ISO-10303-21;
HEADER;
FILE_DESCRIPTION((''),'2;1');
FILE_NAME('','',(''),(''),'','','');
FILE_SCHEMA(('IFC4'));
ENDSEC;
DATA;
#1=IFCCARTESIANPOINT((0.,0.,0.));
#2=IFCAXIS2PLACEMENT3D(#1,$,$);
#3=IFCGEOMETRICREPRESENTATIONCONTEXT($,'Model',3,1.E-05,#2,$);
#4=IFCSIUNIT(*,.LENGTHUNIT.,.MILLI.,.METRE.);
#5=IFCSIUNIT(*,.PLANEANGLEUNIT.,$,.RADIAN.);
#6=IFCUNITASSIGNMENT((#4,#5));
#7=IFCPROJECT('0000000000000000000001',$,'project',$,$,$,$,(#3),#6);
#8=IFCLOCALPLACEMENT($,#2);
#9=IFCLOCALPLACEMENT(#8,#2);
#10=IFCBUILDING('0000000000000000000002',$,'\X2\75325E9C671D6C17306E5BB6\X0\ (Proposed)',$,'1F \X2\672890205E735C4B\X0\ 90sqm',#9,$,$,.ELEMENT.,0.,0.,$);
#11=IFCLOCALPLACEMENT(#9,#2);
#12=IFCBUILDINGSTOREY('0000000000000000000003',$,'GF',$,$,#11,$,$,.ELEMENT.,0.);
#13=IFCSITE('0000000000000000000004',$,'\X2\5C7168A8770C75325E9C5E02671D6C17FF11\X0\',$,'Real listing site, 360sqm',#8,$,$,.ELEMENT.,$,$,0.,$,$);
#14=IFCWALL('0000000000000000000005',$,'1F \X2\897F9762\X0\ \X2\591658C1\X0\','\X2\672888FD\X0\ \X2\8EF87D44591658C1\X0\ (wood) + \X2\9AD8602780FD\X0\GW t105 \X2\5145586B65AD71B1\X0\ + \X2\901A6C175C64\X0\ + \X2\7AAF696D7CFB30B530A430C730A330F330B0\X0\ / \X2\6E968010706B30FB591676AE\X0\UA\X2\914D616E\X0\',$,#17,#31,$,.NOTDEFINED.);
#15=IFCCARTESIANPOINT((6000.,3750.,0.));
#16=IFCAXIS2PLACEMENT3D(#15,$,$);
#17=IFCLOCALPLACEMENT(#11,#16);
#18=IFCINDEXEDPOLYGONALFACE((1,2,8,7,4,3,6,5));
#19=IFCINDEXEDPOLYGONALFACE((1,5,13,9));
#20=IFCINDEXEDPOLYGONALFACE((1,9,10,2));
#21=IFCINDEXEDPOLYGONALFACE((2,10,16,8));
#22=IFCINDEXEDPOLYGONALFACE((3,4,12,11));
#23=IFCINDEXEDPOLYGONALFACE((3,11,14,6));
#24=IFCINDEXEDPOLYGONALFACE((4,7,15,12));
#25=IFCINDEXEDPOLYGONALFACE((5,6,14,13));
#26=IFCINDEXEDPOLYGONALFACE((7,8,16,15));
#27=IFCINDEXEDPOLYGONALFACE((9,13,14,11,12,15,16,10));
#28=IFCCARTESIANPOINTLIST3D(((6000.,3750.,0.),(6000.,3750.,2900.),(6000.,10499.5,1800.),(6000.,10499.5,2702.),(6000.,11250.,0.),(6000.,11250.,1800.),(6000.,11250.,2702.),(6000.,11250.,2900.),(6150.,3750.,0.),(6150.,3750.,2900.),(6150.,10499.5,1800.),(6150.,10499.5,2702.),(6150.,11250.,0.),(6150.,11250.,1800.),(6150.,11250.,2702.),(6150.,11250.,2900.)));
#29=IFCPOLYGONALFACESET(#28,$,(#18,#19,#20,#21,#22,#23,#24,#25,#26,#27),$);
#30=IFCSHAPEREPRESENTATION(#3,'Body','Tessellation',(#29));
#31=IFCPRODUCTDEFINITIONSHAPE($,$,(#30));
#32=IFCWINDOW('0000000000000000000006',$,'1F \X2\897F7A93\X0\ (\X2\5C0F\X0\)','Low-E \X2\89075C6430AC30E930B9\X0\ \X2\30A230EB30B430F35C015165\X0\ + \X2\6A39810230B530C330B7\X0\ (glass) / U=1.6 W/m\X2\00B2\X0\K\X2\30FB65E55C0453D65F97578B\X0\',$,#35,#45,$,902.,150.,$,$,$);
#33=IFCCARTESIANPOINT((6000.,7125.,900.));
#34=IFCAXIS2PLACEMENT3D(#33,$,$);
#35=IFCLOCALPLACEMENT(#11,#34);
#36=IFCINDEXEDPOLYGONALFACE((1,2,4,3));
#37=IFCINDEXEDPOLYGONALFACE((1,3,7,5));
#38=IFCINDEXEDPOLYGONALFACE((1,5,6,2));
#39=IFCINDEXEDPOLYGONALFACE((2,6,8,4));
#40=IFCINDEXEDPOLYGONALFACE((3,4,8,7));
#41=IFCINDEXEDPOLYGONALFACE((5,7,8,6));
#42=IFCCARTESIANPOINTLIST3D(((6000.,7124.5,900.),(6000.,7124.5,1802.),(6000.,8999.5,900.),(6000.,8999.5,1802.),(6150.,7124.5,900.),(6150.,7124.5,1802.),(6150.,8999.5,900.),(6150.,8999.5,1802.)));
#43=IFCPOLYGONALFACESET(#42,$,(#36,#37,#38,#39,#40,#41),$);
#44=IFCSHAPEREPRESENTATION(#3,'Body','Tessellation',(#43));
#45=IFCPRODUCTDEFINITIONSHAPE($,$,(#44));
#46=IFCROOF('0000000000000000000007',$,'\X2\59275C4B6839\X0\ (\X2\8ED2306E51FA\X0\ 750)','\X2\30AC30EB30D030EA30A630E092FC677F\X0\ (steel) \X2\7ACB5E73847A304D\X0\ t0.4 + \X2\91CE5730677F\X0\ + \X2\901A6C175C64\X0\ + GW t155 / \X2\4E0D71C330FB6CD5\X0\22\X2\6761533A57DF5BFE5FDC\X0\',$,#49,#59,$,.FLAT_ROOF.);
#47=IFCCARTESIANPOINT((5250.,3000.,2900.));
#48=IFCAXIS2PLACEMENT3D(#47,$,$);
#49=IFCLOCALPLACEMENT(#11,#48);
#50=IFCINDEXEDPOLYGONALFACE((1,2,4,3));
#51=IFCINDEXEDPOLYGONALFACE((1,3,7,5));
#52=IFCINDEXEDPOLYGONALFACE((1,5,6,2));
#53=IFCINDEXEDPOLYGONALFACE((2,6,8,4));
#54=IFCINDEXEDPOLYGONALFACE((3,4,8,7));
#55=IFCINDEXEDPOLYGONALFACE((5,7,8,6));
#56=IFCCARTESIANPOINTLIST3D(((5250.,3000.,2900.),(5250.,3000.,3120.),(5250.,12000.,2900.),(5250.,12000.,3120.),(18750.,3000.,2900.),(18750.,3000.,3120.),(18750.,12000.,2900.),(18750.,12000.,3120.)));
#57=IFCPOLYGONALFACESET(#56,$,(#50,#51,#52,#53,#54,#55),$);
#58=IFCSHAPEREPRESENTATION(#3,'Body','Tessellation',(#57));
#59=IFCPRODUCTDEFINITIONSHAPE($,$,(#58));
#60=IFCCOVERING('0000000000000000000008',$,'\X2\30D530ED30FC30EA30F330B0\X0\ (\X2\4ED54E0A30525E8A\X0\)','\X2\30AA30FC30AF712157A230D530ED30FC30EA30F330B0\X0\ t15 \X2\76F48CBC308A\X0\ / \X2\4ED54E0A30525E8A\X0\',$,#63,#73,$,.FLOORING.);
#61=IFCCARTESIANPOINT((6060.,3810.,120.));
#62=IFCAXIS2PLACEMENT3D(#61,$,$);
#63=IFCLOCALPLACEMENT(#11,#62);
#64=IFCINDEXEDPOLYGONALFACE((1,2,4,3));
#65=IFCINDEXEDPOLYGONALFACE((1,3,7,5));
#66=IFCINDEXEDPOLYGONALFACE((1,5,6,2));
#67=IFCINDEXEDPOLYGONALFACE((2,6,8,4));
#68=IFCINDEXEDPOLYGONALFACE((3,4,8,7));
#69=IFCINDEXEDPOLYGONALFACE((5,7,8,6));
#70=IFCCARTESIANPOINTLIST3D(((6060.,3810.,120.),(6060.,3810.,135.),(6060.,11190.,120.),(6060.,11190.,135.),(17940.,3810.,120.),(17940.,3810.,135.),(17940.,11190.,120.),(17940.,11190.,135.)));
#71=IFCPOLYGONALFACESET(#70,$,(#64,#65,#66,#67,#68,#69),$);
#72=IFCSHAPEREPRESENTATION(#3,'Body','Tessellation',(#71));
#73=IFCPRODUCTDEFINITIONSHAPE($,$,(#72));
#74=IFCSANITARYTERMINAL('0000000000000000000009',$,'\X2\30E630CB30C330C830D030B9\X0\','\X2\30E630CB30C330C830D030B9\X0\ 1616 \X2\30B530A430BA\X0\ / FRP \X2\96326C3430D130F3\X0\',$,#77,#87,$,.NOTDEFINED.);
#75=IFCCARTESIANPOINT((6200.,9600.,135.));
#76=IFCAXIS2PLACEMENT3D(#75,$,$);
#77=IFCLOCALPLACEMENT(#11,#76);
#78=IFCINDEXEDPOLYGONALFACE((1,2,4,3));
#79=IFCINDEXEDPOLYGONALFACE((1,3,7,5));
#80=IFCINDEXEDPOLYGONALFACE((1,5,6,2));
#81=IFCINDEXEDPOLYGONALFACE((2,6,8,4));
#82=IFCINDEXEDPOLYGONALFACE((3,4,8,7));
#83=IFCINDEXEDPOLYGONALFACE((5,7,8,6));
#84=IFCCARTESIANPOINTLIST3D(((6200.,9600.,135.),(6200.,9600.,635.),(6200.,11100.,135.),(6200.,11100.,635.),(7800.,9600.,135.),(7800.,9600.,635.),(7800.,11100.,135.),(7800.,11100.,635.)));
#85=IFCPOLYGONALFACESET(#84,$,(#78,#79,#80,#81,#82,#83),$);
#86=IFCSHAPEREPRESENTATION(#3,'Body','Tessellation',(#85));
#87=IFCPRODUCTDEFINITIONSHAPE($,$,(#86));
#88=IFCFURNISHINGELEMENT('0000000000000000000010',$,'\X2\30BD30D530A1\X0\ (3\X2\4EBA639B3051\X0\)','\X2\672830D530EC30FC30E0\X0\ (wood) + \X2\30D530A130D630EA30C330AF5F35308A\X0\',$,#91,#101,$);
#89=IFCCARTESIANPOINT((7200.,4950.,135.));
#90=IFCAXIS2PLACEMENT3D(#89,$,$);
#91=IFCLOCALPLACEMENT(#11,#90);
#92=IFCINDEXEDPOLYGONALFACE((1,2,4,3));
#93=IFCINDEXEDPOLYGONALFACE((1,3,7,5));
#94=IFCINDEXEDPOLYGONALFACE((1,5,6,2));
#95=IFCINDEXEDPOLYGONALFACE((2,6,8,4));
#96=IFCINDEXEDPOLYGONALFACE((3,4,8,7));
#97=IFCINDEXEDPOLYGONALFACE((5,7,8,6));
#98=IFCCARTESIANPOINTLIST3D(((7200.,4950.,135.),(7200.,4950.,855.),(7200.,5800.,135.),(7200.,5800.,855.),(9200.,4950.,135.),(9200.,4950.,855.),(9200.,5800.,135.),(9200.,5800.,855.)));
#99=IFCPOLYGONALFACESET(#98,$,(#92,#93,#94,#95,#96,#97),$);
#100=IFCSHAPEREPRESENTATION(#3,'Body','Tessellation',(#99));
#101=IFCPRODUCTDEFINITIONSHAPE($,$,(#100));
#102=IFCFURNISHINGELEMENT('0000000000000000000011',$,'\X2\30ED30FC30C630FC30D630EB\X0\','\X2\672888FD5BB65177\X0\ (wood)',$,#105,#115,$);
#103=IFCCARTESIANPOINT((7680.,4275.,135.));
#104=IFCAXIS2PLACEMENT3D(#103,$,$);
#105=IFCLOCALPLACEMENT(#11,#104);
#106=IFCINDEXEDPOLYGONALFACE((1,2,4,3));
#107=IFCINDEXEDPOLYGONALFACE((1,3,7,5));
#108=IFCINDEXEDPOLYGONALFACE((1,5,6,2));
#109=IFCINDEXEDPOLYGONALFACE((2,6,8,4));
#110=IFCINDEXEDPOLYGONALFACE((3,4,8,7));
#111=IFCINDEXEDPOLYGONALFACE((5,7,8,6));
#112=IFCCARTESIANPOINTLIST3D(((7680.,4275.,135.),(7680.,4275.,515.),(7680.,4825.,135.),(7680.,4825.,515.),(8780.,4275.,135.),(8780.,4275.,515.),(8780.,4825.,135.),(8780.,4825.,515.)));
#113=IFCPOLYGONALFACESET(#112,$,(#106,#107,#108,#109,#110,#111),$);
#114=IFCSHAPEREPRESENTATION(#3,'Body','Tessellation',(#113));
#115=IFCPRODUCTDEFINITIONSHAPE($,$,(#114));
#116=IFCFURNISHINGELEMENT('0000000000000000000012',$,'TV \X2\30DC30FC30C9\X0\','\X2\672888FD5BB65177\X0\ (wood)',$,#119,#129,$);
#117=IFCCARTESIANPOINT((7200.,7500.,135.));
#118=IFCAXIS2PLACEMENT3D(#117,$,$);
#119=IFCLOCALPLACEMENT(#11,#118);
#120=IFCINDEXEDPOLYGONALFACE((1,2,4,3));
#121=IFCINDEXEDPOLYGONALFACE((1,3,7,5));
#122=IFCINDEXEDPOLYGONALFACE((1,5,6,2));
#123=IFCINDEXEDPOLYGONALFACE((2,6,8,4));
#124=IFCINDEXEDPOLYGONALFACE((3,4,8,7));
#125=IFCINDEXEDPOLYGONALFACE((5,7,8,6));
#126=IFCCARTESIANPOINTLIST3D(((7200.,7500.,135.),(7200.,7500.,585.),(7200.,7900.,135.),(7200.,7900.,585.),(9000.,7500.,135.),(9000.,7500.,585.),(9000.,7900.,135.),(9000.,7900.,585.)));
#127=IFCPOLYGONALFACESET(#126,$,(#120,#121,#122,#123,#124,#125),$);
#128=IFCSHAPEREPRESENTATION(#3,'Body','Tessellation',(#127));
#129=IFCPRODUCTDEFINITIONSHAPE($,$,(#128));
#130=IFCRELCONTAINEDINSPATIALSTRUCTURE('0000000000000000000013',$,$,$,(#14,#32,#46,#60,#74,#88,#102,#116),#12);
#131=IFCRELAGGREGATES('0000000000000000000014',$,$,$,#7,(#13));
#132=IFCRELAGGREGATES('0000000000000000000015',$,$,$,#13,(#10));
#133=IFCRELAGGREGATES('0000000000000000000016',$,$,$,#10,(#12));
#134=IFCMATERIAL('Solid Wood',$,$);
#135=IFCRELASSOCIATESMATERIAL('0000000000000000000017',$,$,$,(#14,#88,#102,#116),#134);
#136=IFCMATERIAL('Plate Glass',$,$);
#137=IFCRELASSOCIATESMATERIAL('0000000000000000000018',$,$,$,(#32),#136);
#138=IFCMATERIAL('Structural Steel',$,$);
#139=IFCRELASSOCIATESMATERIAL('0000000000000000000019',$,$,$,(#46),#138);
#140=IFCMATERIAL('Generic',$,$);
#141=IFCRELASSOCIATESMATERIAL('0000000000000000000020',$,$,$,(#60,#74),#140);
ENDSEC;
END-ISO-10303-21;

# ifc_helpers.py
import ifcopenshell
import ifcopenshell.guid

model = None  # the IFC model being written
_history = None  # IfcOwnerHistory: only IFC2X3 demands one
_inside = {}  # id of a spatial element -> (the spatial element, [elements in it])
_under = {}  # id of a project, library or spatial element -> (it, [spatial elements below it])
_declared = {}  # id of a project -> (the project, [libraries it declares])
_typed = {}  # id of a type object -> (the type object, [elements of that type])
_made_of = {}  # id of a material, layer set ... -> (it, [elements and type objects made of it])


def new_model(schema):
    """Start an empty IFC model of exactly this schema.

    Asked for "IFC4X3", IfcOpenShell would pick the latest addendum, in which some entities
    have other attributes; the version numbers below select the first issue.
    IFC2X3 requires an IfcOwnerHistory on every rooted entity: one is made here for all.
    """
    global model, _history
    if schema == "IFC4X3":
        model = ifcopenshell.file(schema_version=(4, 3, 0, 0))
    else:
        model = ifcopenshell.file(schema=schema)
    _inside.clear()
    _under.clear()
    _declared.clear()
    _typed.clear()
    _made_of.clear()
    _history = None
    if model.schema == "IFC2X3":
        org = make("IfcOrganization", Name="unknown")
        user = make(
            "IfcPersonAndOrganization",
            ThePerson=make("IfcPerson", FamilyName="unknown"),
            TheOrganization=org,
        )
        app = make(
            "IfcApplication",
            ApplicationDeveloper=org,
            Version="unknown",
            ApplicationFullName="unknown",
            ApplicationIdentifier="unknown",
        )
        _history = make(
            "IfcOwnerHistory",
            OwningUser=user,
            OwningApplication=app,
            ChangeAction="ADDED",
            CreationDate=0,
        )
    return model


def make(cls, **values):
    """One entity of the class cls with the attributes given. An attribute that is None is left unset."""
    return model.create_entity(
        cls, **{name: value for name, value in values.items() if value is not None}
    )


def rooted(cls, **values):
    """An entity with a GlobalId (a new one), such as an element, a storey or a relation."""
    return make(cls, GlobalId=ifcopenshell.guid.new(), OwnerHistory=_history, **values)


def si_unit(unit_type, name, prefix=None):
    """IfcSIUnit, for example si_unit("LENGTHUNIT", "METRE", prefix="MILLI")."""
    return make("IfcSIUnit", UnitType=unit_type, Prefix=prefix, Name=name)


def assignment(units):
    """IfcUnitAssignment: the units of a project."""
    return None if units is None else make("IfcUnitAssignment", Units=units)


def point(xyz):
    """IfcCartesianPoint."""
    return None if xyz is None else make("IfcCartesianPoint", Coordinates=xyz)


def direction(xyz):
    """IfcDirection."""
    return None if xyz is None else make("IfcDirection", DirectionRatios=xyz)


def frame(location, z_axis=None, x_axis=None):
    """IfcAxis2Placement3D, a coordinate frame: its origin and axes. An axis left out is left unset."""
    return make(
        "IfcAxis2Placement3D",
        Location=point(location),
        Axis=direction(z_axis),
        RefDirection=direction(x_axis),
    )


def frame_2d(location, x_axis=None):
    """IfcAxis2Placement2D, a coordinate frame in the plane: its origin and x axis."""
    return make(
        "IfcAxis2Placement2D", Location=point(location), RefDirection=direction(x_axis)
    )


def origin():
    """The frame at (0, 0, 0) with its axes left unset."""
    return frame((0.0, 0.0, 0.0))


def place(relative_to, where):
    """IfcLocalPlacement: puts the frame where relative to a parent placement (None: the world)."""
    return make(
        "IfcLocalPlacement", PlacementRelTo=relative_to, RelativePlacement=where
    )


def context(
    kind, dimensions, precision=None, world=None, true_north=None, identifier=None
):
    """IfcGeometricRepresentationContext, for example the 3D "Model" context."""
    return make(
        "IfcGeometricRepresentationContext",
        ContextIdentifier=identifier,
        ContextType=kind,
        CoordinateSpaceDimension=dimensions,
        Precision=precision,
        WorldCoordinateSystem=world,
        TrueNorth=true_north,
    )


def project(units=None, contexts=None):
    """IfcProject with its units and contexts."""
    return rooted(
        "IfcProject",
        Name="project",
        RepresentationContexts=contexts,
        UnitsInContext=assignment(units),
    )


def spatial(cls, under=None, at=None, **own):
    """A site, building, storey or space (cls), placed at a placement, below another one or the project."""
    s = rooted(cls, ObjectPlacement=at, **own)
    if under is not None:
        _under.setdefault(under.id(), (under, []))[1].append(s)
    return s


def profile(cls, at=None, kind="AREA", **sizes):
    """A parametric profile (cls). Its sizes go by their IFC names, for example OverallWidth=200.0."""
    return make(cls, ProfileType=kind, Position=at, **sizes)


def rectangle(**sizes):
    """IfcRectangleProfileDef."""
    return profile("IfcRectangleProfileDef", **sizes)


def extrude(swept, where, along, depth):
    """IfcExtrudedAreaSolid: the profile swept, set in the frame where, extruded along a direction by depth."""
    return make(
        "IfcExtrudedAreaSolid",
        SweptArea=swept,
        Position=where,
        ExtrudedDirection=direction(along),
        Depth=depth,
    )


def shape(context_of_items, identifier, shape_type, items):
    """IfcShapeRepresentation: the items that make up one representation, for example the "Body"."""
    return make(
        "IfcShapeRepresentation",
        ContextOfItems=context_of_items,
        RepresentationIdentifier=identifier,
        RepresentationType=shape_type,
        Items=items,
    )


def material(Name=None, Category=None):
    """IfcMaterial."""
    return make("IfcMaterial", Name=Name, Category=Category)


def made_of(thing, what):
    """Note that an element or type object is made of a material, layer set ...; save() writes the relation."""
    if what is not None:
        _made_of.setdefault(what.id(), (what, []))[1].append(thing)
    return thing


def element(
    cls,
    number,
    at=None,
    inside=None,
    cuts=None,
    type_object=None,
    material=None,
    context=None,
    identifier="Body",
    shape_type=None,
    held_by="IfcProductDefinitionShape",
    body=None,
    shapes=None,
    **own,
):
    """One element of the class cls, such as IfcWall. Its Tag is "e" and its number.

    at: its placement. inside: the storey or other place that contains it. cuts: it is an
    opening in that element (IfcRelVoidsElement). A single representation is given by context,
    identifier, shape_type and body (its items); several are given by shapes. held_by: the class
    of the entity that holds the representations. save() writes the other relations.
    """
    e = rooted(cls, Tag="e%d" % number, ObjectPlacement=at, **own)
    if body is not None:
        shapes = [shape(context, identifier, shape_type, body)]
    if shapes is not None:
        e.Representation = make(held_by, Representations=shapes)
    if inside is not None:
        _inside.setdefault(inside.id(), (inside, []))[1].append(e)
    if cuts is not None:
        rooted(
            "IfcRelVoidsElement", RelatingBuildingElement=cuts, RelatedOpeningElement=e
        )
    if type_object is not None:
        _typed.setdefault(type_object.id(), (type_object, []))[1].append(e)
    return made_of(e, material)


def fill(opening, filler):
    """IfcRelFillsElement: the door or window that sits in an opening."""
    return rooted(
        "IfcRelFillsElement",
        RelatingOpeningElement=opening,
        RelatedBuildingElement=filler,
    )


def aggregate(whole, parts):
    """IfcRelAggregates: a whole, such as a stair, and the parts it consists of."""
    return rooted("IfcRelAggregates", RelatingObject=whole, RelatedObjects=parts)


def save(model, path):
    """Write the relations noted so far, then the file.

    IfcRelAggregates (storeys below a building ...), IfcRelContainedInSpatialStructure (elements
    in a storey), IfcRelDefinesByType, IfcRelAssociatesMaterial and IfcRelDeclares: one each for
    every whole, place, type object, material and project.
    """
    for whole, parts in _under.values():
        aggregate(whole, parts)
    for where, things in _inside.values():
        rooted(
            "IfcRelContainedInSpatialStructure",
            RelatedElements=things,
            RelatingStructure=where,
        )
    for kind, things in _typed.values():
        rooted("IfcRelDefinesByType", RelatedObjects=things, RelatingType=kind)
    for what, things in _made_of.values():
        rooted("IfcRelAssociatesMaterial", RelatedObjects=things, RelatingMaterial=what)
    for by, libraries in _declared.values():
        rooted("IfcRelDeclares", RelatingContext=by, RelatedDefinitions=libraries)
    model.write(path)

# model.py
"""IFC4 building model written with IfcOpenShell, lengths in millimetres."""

from ifc_helpers import new_model, si_unit, frame, frame_2d, origin, place, context, project, spatial, rectangle, extrude, material, element, fill, save


model = new_model("IFC4")

# Units and contexts
model_context = context("Model", 3, precision=1e-05, world=origin())
ifc_project = project(units=[si_unit("LENGTHUNIT", "METRE", prefix="MILLI"), si_unit("PLANEANGLEUNIT", "RADIAN")], contexts=[model_context])

# Site, building, storey
site_placement = place(None, origin())
site = spatial("IfcSite", under=ifc_project, at=site_placement, Name="山梨県甲府市朝気１", ObjectType="Real listing site, 360sqm", CompositionType="ELEMENT", RefElevation=0.0)
building_placement = place(site_placement, origin())
building = spatial("IfcBuilding", under=site, at=building_placement, Name="甲府朝気の家 (Proposed)", ObjectType="1F 木造平屋 90sqm", CompositionType="ELEMENT", ElevationOfRefHeight=0.0, ElevationOfTerrain=0.0)
storey_placement = place(building_placement, origin())
storey = spatial("IfcBuildingStorey", under=building, at=storey_placement, Name="GF", CompositionType="ELEMENT", Elevation=0.0)

# Shared definitions
ifc_material_1 = material(Name="Solid Wood")

# Shared definitions
ifc_material_2 = material(Name="Plate Glass")

# Wall, opening, window
wall_1_placement = place(storey_placement, frame((6000.0, 3750.0, 0.0)))
wall_1 = element("IfcWall", 1, at=wall_1_placement, inside=storey, material=ifc_material_1, Name="1F 西面 外壁", Description="木製 軸組外壁 (wood) + 高性能GW t105 充填断熱 + 通気層 + 窯業系サイディング / 準耐火・外皮UA配慮", PredefinedType="NOTDEFINED", context=model_context, shape_type="SweptSolid", body=[
    extrude(rectangle(XDim=150.0, YDim=7500.0, at=frame_2d((75.0, 3750.0))), frame((6000.0, 3750.0, 0.0)), (0.0, 0.0, 1.0), 2900.0),
])
opening_1_placement = place(storey_placement, frame((6000.0, 7125.0, 900.0)))
opening_1 = element("IfcOpeningElement", 2, at=opening_1_placement, cuts=wall_1, PredefinedType="NOTDEFINED", context=model_context, shape_type="SweptSolid", body=[
    extrude(rectangle(XDim=150.0, YDim=1875.0, at=frame_2d((75.0, 937.0))), frame((6000.0, 7125.0, 900.0)), (0.0, 0.0, 1.0), 902.0),
])
window_1_placement = place(storey_placement, frame((6000.0, 7125.0, 900.0)))
window_1 = element("IfcWindow", 3, at=window_1_placement, inside=storey, material=ifc_material_2, Name="1F 西窓 (小)", Description="Low-E 複層ガラス アルゴン封入 + 樹脂サッシ (glass) / U=1.6 W/m²K・日射取得型", OverallHeight=902.0, OverallWidth=150.0, context=model_context, shape_type="SweptSolid", body=[
    extrude(rectangle(XDim=150.0, YDim=1875.0, at=frame_2d((75.0, 937.0))), frame((6000.0, 7125.0, 900.0)), (0.0, 0.0, 1.0), 902.0),
])
fill(opening_1, window_1)

# Roof
ifc_material_3 = material(Name="Structural Steel")
roof_placement = place(storey_placement, frame((5250.0, 3000.0, 2900.0)))
element("IfcRoof", 4, at=roof_placement, inside=storey, material=ifc_material_3, Name="大屋根 (軒の出 750)", Description="ガルバリウム鋼板 (steel) 立平葺き t0.4 + 野地板 + 通気層 + GW t155 / 不燃・法22条区域対応", PredefinedType="FLAT_ROOF", context=model_context, shape_type="SweptSolid", body=[
    extrude(rectangle(XDim=13500.0, YDim=9000.0, at=frame_2d((6750.0, 4500.0))), frame((5250.0, 3000.0, 2900.0)), (0.0, 0.0, 1.0), 220.0),
])

# Covering
ifc_material_4 = material(Name="Generic")
covering_placement = place(storey_placement, frame((6060.0, 3810.0, 120.0)))
element("IfcCovering", 5, at=covering_placement, inside=storey, material=ifc_material_4, Name="フローリング (仕上げ床)", Description="オーク無垢フローリング t15 直貼り / 仕上げ床", PredefinedType="FLOORING", context=model_context, shape_type="SweptSolid", body=[
    extrude(rectangle(XDim=11880.0, YDim=7380.0, at=frame_2d((5940.0, 3690.0))), frame((6060.0, 3810.0, 120.0)), (0.0, 0.0, 1.0), 15.0),
])

# Sanitary terminal
sanitary_terminal_placement = place(storey_placement, frame((6200.0, 9600.0, 135.0)))
element("IfcSanitaryTerminal", 6, at=sanitary_terminal_placement, inside=storey, material=ifc_material_4, Name="ユニットバス", Description="ユニットバス 1616 サイズ / FRP 防水パン", PredefinedType="NOTDEFINED", context=model_context, shape_type="SweptSolid", body=[
    extrude(rectangle(XDim=1600.0, YDim=1500.0, at=frame_2d((800.0, 750.0))), frame((6200.0, 9600.0, 135.0)), (0.0, 0.0, 1.0), 500.0),
])

# Furnishing elements
furnishing_1_placement = place(storey_placement, frame((7200.0, 4950.0, 135.0)))
element("IfcFurnishingElement", 7, at=furnishing_1_placement, inside=storey, material=ifc_material_1, Name="ソファ (3人掛け)", Description="木フレーム (wood) + ファブリック張り", context=model_context, shape_type="SweptSolid", body=[
    extrude(rectangle(XDim=2000.0, YDim=850.0, at=frame_2d((1000.0, 425.0))), frame((7200.0, 4950.0, 135.0)), (0.0, 0.0, 1.0), 720.0),
])
furnishing_2_placement = place(storey_placement, frame((7680.0, 4275.0, 135.0)))
element("IfcFurnishingElement", 8, at=furnishing_2_placement, inside=storey, material=ifc_material_1, Name="ローテーブル", Description="木製家具 (wood)", context=model_context, shape_type="SweptSolid", body=[
    extrude(rectangle(XDim=1100.0, YDim=550.0, at=frame_2d((550.0, 275.0))), frame((7680.0, 4275.0, 135.0)), (0.0, 0.0, 1.0), 380.0),
])
furnishing_3_placement = place(storey_placement, frame((7200.0, 7500.0, 135.0)))
element("IfcFurnishingElement", 9, at=furnishing_3_placement, inside=storey, material=ifc_material_1, Name="TV ボード", Description="木製家具 (wood)", context=model_context, shape_type="SweptSolid", body=[
    extrude(rectangle(XDim=1800.0, YDim=400.0, at=frame_2d((900.0, 200.0))), frame((7200.0, 7500.0, 135.0)), (0.0, 0.0, 1.0), 450.0),
])

save(model, "model.ifc")
